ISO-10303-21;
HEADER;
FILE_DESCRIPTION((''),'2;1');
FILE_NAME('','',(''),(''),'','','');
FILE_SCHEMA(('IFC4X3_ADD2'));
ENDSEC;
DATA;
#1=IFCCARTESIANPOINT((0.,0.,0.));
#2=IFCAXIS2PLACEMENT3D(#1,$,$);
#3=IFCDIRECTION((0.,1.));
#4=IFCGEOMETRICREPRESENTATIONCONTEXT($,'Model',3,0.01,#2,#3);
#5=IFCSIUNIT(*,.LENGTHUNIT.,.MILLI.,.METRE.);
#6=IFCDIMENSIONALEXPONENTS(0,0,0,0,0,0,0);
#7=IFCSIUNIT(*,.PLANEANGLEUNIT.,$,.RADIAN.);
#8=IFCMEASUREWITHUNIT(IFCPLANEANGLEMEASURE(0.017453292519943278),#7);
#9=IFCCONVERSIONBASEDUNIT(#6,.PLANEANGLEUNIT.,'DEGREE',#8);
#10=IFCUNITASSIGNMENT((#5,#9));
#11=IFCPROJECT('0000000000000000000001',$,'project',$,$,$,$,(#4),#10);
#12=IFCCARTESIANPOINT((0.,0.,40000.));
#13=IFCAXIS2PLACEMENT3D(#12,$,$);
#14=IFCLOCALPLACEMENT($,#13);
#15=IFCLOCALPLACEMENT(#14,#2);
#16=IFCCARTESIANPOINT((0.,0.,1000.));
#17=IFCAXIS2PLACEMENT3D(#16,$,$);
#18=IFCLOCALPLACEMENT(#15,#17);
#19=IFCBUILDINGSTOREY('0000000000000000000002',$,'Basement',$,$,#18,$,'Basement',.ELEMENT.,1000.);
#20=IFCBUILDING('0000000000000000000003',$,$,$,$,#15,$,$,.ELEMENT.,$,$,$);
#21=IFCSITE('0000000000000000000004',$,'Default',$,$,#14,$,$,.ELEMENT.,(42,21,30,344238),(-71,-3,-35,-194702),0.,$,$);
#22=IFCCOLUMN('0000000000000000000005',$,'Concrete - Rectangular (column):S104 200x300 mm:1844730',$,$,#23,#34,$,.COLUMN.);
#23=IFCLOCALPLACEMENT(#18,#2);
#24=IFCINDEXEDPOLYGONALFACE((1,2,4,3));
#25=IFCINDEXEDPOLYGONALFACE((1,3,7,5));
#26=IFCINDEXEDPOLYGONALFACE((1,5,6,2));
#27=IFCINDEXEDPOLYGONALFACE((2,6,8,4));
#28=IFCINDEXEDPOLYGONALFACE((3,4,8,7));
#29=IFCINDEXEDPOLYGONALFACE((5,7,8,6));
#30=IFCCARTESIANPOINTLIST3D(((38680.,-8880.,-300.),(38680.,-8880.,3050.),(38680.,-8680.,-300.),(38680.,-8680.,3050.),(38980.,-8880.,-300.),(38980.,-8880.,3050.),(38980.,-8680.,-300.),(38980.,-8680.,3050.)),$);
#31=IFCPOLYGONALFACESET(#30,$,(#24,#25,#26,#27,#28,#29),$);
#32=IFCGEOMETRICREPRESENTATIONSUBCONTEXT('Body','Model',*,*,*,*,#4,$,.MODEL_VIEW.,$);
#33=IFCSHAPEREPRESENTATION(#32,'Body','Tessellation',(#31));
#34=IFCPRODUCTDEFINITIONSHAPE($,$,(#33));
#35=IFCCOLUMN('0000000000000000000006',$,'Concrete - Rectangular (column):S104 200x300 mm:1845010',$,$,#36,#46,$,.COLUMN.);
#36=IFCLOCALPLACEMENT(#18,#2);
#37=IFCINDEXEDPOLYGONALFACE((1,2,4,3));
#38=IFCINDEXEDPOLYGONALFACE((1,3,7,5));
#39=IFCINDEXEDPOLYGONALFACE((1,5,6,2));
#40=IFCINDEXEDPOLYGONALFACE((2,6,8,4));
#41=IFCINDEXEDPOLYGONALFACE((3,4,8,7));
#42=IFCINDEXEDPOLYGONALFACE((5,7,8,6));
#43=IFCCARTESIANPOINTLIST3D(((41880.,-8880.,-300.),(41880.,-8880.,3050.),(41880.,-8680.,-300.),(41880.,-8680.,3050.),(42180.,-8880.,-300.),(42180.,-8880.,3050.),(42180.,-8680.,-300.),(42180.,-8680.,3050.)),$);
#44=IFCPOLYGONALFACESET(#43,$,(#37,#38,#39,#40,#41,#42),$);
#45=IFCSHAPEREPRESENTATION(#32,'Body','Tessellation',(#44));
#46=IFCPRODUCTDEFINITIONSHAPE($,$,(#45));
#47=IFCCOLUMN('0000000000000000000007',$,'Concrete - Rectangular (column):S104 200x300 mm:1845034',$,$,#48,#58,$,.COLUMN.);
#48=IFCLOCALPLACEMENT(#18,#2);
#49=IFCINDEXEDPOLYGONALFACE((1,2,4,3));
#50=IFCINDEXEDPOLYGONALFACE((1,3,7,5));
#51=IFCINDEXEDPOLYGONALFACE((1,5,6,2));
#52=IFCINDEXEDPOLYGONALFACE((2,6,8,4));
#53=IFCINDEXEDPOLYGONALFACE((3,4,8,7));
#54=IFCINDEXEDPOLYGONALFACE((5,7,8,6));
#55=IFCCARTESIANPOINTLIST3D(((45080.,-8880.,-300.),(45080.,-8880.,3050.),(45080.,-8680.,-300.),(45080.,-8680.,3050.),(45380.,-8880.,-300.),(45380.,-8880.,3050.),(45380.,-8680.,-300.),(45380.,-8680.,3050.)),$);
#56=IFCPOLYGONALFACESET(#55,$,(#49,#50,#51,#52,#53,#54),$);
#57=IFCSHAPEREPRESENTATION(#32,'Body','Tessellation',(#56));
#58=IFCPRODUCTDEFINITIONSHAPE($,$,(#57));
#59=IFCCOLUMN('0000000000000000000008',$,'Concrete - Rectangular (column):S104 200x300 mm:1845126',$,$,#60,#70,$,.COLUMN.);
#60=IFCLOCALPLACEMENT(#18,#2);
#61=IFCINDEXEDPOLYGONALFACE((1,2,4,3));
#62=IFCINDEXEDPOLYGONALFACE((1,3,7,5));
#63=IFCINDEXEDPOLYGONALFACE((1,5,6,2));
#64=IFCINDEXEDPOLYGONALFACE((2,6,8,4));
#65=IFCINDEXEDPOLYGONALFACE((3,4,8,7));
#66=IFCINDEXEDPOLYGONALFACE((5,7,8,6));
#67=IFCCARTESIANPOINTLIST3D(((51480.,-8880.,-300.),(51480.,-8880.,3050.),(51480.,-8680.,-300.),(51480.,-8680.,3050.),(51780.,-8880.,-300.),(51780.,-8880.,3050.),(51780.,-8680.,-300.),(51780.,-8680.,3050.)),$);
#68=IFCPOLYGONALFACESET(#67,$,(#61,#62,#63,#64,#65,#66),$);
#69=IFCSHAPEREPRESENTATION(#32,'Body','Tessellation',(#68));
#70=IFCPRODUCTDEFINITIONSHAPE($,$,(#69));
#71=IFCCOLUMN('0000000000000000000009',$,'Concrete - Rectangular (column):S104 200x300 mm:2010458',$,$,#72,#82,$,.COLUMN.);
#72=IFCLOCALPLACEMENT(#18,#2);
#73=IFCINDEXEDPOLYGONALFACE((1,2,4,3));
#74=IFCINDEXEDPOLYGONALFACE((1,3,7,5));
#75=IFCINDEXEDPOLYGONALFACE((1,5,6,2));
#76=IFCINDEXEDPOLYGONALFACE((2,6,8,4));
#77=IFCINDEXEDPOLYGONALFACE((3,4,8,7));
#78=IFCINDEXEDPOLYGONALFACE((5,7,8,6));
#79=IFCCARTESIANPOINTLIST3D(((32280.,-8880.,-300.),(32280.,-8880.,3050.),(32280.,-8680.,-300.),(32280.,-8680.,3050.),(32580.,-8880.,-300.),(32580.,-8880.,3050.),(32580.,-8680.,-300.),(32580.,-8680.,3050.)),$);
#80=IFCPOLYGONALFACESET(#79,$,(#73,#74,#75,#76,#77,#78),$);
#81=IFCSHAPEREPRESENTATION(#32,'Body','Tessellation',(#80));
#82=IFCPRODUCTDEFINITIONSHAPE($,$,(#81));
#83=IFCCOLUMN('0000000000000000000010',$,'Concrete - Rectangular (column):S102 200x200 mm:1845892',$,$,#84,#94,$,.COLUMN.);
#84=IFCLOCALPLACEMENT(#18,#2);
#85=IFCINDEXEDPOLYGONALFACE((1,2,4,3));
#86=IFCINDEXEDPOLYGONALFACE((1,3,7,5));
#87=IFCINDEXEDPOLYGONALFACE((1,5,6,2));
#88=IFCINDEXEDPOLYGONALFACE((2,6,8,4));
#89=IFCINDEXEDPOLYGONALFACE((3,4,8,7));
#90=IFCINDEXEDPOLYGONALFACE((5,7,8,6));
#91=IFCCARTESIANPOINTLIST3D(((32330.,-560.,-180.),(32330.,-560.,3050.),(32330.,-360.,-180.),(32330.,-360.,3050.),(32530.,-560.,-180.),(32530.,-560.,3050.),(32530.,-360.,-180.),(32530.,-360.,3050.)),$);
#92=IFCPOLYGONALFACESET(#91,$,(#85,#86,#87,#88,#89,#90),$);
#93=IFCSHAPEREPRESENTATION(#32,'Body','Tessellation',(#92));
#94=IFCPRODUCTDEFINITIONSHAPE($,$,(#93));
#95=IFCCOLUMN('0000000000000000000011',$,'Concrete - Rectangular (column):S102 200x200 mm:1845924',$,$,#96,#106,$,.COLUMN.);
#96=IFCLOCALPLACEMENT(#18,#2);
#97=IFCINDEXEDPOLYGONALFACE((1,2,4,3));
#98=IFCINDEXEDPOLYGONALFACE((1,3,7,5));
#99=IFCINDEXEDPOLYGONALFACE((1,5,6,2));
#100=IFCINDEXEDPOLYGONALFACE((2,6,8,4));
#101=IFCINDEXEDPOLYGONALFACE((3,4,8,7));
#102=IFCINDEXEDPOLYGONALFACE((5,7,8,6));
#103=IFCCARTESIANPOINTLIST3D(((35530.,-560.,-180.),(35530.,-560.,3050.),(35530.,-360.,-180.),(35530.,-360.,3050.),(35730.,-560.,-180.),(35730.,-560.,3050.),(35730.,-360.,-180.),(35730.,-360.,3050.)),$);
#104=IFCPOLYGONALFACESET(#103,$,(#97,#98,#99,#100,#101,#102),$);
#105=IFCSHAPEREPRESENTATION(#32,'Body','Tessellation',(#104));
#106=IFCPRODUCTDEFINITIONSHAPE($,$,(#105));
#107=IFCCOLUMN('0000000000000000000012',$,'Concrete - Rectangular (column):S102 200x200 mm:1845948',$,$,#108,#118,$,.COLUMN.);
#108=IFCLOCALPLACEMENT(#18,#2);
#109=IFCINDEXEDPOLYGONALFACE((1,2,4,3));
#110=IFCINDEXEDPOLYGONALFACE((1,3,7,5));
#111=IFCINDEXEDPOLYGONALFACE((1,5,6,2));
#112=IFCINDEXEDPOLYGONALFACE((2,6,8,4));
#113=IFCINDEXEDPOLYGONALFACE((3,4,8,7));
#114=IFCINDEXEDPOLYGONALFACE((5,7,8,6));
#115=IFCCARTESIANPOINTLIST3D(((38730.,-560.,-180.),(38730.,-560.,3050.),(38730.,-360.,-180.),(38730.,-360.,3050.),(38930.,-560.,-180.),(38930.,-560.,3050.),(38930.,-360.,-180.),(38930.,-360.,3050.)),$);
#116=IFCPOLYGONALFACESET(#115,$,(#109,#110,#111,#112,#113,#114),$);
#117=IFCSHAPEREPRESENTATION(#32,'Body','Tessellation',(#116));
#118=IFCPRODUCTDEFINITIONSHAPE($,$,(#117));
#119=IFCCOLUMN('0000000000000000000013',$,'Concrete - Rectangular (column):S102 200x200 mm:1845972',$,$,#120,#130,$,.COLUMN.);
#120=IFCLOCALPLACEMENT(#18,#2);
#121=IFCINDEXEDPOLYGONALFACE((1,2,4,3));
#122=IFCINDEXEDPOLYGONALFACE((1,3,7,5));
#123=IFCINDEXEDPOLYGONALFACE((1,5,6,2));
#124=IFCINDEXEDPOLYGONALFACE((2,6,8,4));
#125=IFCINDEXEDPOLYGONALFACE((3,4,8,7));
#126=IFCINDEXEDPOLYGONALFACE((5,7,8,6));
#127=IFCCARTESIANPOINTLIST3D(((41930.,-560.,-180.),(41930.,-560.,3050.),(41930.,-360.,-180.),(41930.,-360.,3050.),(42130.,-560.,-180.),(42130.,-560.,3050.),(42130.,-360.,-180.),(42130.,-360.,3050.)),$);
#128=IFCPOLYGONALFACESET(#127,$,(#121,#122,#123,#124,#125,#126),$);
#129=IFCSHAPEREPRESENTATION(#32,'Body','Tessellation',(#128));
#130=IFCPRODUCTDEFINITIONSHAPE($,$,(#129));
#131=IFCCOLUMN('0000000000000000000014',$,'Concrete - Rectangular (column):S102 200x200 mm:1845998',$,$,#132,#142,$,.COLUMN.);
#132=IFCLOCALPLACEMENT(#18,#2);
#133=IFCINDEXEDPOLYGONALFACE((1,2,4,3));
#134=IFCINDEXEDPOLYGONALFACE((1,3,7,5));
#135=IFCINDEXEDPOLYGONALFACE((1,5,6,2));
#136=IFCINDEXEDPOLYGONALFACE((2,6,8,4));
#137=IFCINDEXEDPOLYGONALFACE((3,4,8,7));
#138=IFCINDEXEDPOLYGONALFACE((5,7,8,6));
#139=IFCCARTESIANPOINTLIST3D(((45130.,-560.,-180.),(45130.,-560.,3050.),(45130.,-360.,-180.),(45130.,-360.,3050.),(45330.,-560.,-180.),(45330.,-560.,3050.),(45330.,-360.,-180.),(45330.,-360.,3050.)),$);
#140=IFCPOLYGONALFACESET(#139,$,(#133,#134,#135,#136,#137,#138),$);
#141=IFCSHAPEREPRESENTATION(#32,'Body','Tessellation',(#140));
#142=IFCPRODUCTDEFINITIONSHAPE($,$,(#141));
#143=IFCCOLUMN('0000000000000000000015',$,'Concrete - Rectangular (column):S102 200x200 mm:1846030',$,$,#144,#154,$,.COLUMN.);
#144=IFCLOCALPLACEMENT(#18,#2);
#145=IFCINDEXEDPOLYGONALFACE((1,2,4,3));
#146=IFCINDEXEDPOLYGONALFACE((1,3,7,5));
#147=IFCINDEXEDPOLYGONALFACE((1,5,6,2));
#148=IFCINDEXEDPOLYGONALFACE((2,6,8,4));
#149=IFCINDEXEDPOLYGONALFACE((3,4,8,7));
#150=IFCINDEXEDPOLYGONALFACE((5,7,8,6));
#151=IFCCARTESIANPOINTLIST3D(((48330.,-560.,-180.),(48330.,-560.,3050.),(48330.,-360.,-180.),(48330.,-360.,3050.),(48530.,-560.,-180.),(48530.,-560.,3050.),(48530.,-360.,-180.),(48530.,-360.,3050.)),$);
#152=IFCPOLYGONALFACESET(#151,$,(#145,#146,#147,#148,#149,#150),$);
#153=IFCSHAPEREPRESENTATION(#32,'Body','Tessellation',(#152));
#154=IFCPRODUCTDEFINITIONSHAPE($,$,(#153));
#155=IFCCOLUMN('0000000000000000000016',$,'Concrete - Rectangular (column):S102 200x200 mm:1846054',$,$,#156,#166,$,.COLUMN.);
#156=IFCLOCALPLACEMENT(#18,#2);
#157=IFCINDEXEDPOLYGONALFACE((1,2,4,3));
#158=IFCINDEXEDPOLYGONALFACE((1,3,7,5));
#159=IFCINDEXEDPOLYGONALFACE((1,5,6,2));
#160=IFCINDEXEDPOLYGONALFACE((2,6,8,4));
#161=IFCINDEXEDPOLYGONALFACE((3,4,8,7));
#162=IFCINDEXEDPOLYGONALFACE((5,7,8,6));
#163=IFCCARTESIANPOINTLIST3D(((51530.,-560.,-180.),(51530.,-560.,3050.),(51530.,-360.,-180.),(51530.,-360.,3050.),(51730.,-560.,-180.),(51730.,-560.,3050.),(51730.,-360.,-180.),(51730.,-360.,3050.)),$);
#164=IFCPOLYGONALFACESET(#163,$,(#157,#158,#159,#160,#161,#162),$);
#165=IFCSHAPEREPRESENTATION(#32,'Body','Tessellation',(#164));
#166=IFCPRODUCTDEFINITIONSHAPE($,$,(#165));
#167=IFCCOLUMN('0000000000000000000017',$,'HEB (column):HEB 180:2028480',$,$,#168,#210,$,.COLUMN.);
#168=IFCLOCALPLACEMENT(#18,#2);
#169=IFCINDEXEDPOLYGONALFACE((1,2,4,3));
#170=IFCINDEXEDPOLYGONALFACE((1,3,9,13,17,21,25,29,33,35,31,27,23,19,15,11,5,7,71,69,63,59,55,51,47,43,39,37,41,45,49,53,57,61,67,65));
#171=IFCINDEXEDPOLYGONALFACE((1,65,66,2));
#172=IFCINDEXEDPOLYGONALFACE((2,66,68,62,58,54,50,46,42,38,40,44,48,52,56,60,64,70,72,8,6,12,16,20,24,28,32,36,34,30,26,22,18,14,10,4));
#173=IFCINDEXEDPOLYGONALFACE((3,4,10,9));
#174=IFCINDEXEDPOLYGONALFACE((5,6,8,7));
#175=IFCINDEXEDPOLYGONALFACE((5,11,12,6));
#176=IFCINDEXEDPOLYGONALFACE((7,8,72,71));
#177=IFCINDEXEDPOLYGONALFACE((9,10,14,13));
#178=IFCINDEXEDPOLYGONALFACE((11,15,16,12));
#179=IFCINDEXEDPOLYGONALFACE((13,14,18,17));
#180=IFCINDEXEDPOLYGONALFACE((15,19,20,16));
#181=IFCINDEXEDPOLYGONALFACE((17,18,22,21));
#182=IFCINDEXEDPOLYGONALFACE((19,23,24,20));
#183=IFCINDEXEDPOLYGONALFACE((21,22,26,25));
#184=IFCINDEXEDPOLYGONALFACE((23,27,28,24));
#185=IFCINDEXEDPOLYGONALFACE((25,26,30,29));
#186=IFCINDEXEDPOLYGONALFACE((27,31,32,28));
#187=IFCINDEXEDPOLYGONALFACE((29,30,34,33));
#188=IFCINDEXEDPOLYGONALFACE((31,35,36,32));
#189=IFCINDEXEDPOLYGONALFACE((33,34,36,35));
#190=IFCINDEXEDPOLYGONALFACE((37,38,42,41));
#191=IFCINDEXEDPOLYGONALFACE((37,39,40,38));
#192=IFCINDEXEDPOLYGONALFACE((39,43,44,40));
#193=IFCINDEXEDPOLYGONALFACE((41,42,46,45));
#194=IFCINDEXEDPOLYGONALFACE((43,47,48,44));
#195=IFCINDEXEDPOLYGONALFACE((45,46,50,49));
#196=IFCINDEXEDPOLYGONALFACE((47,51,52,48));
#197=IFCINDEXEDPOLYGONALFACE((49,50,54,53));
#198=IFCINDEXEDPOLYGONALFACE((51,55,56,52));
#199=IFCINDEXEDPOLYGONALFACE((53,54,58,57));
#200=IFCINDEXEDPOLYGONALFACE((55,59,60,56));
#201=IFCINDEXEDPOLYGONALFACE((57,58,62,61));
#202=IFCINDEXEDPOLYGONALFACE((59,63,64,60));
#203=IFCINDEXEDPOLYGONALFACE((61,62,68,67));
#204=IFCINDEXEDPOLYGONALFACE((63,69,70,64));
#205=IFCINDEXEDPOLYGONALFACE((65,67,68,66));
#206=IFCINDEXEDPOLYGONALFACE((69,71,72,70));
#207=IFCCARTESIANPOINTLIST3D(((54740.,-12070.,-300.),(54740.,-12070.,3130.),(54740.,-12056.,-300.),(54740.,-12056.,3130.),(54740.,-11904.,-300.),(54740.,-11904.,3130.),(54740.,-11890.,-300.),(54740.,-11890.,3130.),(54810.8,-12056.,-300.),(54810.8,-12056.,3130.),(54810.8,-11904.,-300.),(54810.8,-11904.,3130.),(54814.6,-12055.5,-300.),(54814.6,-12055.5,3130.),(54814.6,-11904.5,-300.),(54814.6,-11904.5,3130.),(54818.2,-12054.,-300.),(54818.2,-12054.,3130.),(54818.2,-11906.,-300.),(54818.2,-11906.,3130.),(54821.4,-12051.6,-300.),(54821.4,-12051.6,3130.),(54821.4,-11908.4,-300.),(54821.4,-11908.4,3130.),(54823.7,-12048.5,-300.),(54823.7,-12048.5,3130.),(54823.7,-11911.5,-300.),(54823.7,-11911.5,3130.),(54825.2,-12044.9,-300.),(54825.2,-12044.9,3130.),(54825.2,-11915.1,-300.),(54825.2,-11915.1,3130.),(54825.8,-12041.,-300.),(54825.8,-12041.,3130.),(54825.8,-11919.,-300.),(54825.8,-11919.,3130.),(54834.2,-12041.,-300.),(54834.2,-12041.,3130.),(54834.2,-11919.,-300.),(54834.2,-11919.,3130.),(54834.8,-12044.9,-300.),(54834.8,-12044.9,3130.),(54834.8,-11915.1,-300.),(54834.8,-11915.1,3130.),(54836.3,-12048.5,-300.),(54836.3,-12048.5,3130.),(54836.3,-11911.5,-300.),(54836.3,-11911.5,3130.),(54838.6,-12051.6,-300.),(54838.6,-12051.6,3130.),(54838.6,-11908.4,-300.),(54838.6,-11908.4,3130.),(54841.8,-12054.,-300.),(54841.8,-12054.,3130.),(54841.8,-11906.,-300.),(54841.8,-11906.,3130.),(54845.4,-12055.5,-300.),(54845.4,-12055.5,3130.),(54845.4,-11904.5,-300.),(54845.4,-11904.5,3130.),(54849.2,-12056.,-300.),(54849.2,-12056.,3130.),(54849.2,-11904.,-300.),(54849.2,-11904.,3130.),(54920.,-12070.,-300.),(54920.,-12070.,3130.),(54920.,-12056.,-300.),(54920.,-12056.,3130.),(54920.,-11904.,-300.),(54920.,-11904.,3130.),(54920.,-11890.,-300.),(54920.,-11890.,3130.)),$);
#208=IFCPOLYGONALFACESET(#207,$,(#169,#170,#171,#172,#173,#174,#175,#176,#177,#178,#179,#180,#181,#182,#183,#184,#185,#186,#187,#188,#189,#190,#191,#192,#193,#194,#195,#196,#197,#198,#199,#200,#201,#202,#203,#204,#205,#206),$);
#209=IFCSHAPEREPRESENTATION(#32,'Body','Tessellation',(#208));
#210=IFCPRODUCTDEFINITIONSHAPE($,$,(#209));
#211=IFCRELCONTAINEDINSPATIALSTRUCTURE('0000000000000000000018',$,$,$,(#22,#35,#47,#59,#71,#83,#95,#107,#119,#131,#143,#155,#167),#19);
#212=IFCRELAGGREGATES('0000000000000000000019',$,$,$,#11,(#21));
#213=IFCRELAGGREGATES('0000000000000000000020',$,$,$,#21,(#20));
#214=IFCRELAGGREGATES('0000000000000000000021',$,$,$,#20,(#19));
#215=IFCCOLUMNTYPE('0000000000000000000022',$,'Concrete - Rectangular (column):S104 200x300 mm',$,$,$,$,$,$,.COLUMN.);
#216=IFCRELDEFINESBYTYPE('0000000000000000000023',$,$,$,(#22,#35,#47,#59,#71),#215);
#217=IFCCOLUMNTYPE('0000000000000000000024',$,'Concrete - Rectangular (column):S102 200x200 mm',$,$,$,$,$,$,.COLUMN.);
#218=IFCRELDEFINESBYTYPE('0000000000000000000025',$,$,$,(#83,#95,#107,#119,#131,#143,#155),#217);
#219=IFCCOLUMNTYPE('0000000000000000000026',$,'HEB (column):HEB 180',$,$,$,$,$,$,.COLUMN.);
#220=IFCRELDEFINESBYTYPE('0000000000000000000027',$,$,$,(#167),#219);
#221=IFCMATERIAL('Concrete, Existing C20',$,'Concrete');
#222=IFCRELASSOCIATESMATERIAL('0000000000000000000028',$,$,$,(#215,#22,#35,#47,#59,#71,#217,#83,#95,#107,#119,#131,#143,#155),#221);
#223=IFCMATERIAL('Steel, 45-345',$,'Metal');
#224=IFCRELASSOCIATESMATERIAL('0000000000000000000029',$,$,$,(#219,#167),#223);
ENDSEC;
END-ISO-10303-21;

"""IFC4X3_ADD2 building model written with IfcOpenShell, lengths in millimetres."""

from ifc_helpers import new_model, entity, si_unit, converted_unit, direction, frame, frame_2d, origin, origin_2d_with_axis, place, context, subcontext, project, spatial, rectangle, i_section, extrude, source, transform, mapped, material, material_profile, profile_set, profile_usage, type_object, type_shapes, element, save


model = new_model("IFC4X3_ADD2")

# Units and contexts
model_context = context("Model", 3, precision=0.01, world=origin(), true_north=direction((0.0, 1.0)))
body_context = subcontext(model_context, "Body", "Model", "MODEL_VIEW")
ifc_project = project(units=[si_unit("LENGTHUNIT", "METRE", prefix="MILLI"), converted_unit("PLANEANGLEUNIT", "DEGREE", entity("IfcPlaneAngleMeasure", 0.017453292519943278), si_unit("PLANEANGLEUNIT", "RADIAN"), dimensions=[0, 0, 0, 0, 0, 0, 0])], contexts=[model_context])

# Site, building, storey
site_placement = place(None, frame((0.0, 0.0, 40000.0)))
site = spatial("IfcSite", under=ifc_project, at=site_placement, Name="Default", CompositionType="ELEMENT", RefLatitude=(42, 21, 30, 344238), RefLongitude=(-71, -3, -35, -194702), RefElevation=0.0)
building_placement = place(site_placement, origin())
building = spatial("IfcBuilding", under=site, at=building_placement, CompositionType="ELEMENT")
storey_placement = place(building_placement, frame((0.0, 0.0, 1000.0)))
storey = spatial("IfcBuildingStorey", under=building, at=storey_placement, Name="Basement", LongName="Basement", CompositionType="ELEMENT", Elevation=1000.0)

# Columns
ifc_material_1 = material(Name="Concrete, Existing C20", Category="Concrete")
ifc_material_profile_1 = material_profile(ifc_material_1, rectangle(XDim=200.0, YDim=300.0, at=frame_2d((0.0, 0.0), x_axis=(1.0, 0.0))), Name="S104 200x300 mm")
ifc_profile_set_1 = profile_set([ifc_material_profile_1], Name="S104 200x300 mm")
ifc_profile_usage_1 = profile_usage(ifc_profile_set_1)
column_type_1 = type_object("IfcColumnType", Name="Concrete - Rectangular (column):S104 200x300 mm", PredefinedType="COLUMN", material=ifc_profile_set_1)
shared_shape_1 = source(origin(), body_context, "Body", "SweptSolid", [
    extrude(rectangle(XDim=200.0, YDim=300.0, at=origin_2d_with_axis()), frame((0.0, 0.0, 700.0), z_axis=(0.0, 0.0, 1.0), x_axis=(-1.0, 0.0, 0.0)), (0.0, 0.0, 1.0), 3350.0),
])
type_shapes(column_type_1, [shared_shape_1])
for number, where, z_axis, x_axis, name in (
    (1, (38830.0, -8780.0, -1000.0), (0.0, 0.0, 1.0), (0.0, -1.0, 0.0), "Concrete - Rectangular (column):S104 200x300 mm:1844730"),
    (2, (42030.0, -8780.0, -1000.0), (0.0, 0.0, 1.0), (0.0, -1.0, 0.0), "Concrete - Rectangular (column):S104 200x300 mm:1845010"),
    (3, (45230.0, -8780.0, -1000.0), (0.0, 0.0, 1.0), (0.0, -1.0, 0.0), "Concrete - Rectangular (column):S104 200x300 mm:1845034"),
    (4, (51630.0, -8780.0, -1000.0), (0.0, 0.0, 1.0), (0.0, -1.0, 0.0), "Concrete - Rectangular (column):S104 200x300 mm:1845126"),
    (5, (32430.0, -8780.0, -1000.0), (0.0, 0.0, 1.0), (0.0, -1.0, 0.0), "Concrete - Rectangular (column):S104 200x300 mm:2010458"),
):
    element("IfcColumn", number, at=place(storey_placement, frame(where, z_axis=z_axis, x_axis=x_axis)), inside=storey, type_object=column_type_1, material=ifc_profile_usage_1, Name=name, PredefinedType="COLUMN", context=body_context, shape_type="MappedRepresentation", body=[
        mapped(shared_shape_1, transform((0.0, 0.0, 0.0), scale=1.0)),
    ])
ifc_material_profile_2 = material_profile(ifc_material_1, rectangle(XDim=200.0, YDim=200.0, at=frame_2d((0.0, 0.0), x_axis=(1.0, 0.0))), Name="S102 200x200 mm")
ifc_profile_set_2 = profile_set([ifc_material_profile_2], Name="S102 200x200 mm")
ifc_profile_usage_2 = profile_usage(ifc_profile_set_2)
column_type_2 = type_object("IfcColumnType", Name="Concrete - Rectangular (column):S102 200x200 mm", PredefinedType="COLUMN", material=ifc_profile_set_2)
shared_shape_2 = source(origin(), body_context, "Body", "SweptSolid", [
    extrude(rectangle(XDim=200.0, YDim=200.0, at=origin_2d_with_axis()), frame((0.0, 0.0, 820.0), z_axis=(0.0, 0.0, 1.0), x_axis=(-1.0, 0.0, 0.0)), (0.0, 0.0, 1.0), 3230.0),
])
type_shapes(column_type_2, [shared_shape_2])
for number, where, z_axis, x_axis, name in (
    (6, (32430.0, -460.0, -1000.0), (0.0, 0.0, 1.0), (0.0, -1.0, 0.0), "Concrete - Rectangular (column):S102 200x200 mm:1845892"),
    (7, (35630.0, -460.0, -1000.0), (0.0, 0.0, 1.0), (0.0, -1.0, 0.0), "Concrete - Rectangular (column):S102 200x200 mm:1845924"),
    (8, (38830.0, -460.0, -1000.0), (0.0, 0.0, 1.0), (0.0, -1.0, 0.0), "Concrete - Rectangular (column):S102 200x200 mm:1845948"),
    (9, (42030.0, -460.0, -1000.0), (0.0, 0.0, 1.0), (0.0, -1.0, 0.0), "Concrete - Rectangular (column):S102 200x200 mm:1845972"),
    (10, (45230.0, -460.0, -1000.0), (0.0, 0.0, 1.0), (0.0, -1.0, 0.0), "Concrete - Rectangular (column):S102 200x200 mm:1845998"),
    (11, (48430.0, -460.0, -1000.0), (0.0, 0.0, 1.0), (0.0, -1.0, 0.0), "Concrete - Rectangular (column):S102 200x200 mm:1846030"),
    (12, (51630.0, -460.0, -1000.0), (0.0, 0.0, 1.0), (0.0, -1.0, 0.0), "Concrete - Rectangular (column):S102 200x200 mm:1846054"),
):
    element("IfcColumn", number, at=place(storey_placement, frame(where, z_axis=z_axis, x_axis=x_axis)), inside=storey, type_object=column_type_2, material=ifc_profile_usage_2, Name=name, PredefinedType="COLUMN", context=body_context, shape_type="MappedRepresentation", body=[
        mapped(shared_shape_2, transform((0.0, 0.0, 0.0), scale=1.0)),
    ])
ifc_material_2 = material(Name="Steel, 45-345", Category="Metal")
ifc_material_profile_3 = material_profile(ifc_material_2, i_section(OverallWidth=180.0, OverallDepth=180.0, WebThickness=8.5, FlangeThickness=14.0, FilletRadius=15.0, at=origin_2d_with_axis()), Name="HEB 180")
ifc_profile_set_3 = profile_set([ifc_material_profile_3], Name="HEB 180")
ifc_profile_usage_3 = profile_usage(ifc_profile_set_3)
column_type_3 = type_object("IfcColumnType", Name="HEB (column):HEB 180", PredefinedType="COLUMN", material=ifc_profile_set_3)
shared_shape_3 = source(origin(), body_context, "Body", "SweptSolid", [
    extrude(i_section(OverallWidth=180.0, OverallDepth=180.0, WebThickness=8.5, FlangeThickness=14.0, FilletRadius=15.0, at=origin_2d_with_axis()), frame((0.0, 0.0, 700.0), z_axis=(0.0, 0.0, 1.0), x_axis=(-1.0, 0.0, 0.0)), (0.0, 0.0, 1.0), 3430.0),
])
type_shapes(column_type_3, [shared_shape_3])
column_placement = place(storey_placement, frame((54830.0, -11980.0, -1000.0)))
element("IfcColumn", 13, at=column_placement, inside=storey, type_object=column_type_3, material=ifc_profile_usage_3, Name="HEB (column):HEB 180:2028480", PredefinedType="COLUMN", context=body_context, shape_type="MappedRepresentation", body=[
    mapped(shared_shape_3, transform((0.0, 0.0, 0.0), scale=1.0)),
])

save(model, "model.ifc")
